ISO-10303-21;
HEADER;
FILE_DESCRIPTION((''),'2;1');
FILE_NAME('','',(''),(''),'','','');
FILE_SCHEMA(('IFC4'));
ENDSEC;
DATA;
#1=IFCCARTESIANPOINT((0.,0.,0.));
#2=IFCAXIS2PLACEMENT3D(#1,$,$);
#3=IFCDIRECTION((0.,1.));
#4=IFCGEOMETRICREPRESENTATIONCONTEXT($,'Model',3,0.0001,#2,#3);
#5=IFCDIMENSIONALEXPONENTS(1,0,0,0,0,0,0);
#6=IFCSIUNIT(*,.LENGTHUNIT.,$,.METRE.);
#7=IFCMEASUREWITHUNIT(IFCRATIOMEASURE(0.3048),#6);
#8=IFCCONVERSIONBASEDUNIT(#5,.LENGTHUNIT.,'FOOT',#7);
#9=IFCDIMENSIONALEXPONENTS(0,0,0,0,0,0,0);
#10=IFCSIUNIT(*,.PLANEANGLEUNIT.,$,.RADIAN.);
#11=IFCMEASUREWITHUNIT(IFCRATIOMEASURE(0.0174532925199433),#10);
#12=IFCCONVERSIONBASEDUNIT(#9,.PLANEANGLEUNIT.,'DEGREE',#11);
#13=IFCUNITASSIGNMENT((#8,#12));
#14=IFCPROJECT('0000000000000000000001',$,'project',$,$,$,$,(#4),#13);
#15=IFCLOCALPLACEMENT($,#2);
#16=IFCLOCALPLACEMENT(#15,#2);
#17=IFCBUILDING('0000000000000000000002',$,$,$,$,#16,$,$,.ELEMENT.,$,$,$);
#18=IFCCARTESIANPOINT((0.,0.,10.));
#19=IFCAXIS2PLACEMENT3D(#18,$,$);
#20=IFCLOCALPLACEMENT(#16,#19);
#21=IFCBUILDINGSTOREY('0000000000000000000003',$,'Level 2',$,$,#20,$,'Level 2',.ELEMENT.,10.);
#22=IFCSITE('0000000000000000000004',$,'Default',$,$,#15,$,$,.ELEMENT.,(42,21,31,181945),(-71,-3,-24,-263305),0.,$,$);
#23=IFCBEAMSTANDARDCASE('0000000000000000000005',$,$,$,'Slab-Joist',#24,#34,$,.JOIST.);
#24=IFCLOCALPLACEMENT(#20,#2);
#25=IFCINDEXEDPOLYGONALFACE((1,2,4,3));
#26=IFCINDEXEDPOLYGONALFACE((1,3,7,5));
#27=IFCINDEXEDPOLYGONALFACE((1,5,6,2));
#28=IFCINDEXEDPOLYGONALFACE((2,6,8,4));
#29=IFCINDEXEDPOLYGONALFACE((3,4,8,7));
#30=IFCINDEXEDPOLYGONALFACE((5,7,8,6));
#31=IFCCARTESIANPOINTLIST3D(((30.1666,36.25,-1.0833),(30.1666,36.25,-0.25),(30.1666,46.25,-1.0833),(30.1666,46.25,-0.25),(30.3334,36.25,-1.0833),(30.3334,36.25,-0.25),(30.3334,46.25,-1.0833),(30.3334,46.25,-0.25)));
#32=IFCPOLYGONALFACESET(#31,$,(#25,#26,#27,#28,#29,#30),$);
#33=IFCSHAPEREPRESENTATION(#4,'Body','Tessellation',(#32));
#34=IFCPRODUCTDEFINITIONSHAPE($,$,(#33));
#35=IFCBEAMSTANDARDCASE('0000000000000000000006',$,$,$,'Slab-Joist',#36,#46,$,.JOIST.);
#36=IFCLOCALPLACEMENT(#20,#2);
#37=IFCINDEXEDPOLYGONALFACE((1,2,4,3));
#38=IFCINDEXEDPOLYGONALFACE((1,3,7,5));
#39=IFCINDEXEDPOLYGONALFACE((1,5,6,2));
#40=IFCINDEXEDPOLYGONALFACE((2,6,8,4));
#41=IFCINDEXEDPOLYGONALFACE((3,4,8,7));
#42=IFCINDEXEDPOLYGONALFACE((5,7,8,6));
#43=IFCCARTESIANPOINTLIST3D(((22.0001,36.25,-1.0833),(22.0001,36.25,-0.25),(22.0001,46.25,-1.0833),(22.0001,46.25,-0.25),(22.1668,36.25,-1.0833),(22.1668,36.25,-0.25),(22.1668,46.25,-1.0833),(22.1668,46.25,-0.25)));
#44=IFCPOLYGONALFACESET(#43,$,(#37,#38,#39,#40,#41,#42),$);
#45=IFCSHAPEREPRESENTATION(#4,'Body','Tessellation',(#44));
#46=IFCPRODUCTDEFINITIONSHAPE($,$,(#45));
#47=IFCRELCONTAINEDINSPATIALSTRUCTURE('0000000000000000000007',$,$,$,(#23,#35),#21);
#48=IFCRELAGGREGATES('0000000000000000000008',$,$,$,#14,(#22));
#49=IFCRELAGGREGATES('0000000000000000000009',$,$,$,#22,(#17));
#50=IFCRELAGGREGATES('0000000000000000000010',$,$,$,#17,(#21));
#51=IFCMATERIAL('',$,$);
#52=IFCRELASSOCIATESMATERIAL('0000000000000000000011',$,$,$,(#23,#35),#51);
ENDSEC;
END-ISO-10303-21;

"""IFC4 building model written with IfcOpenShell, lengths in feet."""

from ifc_helpers import new_model, entity, si_unit, converted_unit, direction, frame, origin, origin_with_axes, place, context, project, spatial, rectangle, extrude, material, element, save


model = new_model("IFC4")

# Units and contexts
model_context = context("Model", 3, precision=0.0001, world=origin(), true_north=direction((0.0, 1.0)))
ifc_project = project(units=[converted_unit("LENGTHUNIT", "FOOT", entity("IfcRatioMeasure", 0.3048), si_unit("LENGTHUNIT", "METRE"), dimensions=[1, 0, 0, 0, 0, 0, 0]), converted_unit("PLANEANGLEUNIT", "DEGREE", entity("IfcRatioMeasure", 0.0174532925199433), si_unit("PLANEANGLEUNIT", "RADIAN"), dimensions=[0, 0, 0, 0, 0, 0, 0])], contexts=[model_context])

# Site, building, storey
site_placement = place(None, origin())
site = spatial("IfcSite", under=ifc_project, at=site_placement, Name="Default", CompositionType="ELEMENT", RefLatitude=(42, 21, 31, 181945), RefLongitude=(-71, -3, -24, -263305), RefElevation=0.0)
building_placement = place(site_placement, origin())
building = spatial("IfcBuilding", under=site, at=building_placement, CompositionType="ELEMENT")
storey_placement = place(building_placement, frame((0.0, 0.0, 10.0)))
storey = spatial("IfcBuildingStorey", under=building, at=storey_placement, Name="Level 2", LongName="Level 2", CompositionType="ELEMENT", Elevation=10.0)

# Beams
ifc_material = material(Name="")
placement_1 = place(storey_placement, frame((30.25, 36.25, 0.0), z_axis=(0.0, 0.0, 1.0), x_axis=(1.0, 0.0, 0.0)))
beam_1_placement = place(placement_1, frame((0.0, 0.0, -0.6667), z_axis=(0.0, 1.0, 0.0), x_axis=(-1.0, 0.0, 0.0)))
element("IfcBeamStandardCase", 1, at=beam_1_placement, inside=storey, material=ifc_material, ObjectType="Slab-Joist", PredefinedType="JOIST", context=model_context, shape_type="SweptSolid", body=[
    extrude(rectangle(XDim=0.1667, YDim=0.8333), origin_with_axes(), (0.0, 0.0, 1.0), 10.0),
])
placement_2 = place(storey_placement, frame((-0.25, 36.25, 0.0), z_axis=(0.0, 0.0, 1.0), x_axis=(1.0, 0.0, 0.0)))
beam_2_placement = place(placement_2, frame((22.3334, 0.0, -0.6667), z_axis=(0.0, 1.0, 0.0), x_axis=(-1.0, 0.0, 0.0)))
element("IfcBeamStandardCase", 2, at=beam_2_placement, inside=storey, material=ifc_material, ObjectType="Slab-Joist", PredefinedType="JOIST", context=model_context, shape_type="SweptSolid", body=[
    extrude(rectangle(XDim=0.1667, YDim=0.8333), origin_with_axes(), (0.0, 0.0, 1.0), 10.0),
])

save(model, "model.ifc")
